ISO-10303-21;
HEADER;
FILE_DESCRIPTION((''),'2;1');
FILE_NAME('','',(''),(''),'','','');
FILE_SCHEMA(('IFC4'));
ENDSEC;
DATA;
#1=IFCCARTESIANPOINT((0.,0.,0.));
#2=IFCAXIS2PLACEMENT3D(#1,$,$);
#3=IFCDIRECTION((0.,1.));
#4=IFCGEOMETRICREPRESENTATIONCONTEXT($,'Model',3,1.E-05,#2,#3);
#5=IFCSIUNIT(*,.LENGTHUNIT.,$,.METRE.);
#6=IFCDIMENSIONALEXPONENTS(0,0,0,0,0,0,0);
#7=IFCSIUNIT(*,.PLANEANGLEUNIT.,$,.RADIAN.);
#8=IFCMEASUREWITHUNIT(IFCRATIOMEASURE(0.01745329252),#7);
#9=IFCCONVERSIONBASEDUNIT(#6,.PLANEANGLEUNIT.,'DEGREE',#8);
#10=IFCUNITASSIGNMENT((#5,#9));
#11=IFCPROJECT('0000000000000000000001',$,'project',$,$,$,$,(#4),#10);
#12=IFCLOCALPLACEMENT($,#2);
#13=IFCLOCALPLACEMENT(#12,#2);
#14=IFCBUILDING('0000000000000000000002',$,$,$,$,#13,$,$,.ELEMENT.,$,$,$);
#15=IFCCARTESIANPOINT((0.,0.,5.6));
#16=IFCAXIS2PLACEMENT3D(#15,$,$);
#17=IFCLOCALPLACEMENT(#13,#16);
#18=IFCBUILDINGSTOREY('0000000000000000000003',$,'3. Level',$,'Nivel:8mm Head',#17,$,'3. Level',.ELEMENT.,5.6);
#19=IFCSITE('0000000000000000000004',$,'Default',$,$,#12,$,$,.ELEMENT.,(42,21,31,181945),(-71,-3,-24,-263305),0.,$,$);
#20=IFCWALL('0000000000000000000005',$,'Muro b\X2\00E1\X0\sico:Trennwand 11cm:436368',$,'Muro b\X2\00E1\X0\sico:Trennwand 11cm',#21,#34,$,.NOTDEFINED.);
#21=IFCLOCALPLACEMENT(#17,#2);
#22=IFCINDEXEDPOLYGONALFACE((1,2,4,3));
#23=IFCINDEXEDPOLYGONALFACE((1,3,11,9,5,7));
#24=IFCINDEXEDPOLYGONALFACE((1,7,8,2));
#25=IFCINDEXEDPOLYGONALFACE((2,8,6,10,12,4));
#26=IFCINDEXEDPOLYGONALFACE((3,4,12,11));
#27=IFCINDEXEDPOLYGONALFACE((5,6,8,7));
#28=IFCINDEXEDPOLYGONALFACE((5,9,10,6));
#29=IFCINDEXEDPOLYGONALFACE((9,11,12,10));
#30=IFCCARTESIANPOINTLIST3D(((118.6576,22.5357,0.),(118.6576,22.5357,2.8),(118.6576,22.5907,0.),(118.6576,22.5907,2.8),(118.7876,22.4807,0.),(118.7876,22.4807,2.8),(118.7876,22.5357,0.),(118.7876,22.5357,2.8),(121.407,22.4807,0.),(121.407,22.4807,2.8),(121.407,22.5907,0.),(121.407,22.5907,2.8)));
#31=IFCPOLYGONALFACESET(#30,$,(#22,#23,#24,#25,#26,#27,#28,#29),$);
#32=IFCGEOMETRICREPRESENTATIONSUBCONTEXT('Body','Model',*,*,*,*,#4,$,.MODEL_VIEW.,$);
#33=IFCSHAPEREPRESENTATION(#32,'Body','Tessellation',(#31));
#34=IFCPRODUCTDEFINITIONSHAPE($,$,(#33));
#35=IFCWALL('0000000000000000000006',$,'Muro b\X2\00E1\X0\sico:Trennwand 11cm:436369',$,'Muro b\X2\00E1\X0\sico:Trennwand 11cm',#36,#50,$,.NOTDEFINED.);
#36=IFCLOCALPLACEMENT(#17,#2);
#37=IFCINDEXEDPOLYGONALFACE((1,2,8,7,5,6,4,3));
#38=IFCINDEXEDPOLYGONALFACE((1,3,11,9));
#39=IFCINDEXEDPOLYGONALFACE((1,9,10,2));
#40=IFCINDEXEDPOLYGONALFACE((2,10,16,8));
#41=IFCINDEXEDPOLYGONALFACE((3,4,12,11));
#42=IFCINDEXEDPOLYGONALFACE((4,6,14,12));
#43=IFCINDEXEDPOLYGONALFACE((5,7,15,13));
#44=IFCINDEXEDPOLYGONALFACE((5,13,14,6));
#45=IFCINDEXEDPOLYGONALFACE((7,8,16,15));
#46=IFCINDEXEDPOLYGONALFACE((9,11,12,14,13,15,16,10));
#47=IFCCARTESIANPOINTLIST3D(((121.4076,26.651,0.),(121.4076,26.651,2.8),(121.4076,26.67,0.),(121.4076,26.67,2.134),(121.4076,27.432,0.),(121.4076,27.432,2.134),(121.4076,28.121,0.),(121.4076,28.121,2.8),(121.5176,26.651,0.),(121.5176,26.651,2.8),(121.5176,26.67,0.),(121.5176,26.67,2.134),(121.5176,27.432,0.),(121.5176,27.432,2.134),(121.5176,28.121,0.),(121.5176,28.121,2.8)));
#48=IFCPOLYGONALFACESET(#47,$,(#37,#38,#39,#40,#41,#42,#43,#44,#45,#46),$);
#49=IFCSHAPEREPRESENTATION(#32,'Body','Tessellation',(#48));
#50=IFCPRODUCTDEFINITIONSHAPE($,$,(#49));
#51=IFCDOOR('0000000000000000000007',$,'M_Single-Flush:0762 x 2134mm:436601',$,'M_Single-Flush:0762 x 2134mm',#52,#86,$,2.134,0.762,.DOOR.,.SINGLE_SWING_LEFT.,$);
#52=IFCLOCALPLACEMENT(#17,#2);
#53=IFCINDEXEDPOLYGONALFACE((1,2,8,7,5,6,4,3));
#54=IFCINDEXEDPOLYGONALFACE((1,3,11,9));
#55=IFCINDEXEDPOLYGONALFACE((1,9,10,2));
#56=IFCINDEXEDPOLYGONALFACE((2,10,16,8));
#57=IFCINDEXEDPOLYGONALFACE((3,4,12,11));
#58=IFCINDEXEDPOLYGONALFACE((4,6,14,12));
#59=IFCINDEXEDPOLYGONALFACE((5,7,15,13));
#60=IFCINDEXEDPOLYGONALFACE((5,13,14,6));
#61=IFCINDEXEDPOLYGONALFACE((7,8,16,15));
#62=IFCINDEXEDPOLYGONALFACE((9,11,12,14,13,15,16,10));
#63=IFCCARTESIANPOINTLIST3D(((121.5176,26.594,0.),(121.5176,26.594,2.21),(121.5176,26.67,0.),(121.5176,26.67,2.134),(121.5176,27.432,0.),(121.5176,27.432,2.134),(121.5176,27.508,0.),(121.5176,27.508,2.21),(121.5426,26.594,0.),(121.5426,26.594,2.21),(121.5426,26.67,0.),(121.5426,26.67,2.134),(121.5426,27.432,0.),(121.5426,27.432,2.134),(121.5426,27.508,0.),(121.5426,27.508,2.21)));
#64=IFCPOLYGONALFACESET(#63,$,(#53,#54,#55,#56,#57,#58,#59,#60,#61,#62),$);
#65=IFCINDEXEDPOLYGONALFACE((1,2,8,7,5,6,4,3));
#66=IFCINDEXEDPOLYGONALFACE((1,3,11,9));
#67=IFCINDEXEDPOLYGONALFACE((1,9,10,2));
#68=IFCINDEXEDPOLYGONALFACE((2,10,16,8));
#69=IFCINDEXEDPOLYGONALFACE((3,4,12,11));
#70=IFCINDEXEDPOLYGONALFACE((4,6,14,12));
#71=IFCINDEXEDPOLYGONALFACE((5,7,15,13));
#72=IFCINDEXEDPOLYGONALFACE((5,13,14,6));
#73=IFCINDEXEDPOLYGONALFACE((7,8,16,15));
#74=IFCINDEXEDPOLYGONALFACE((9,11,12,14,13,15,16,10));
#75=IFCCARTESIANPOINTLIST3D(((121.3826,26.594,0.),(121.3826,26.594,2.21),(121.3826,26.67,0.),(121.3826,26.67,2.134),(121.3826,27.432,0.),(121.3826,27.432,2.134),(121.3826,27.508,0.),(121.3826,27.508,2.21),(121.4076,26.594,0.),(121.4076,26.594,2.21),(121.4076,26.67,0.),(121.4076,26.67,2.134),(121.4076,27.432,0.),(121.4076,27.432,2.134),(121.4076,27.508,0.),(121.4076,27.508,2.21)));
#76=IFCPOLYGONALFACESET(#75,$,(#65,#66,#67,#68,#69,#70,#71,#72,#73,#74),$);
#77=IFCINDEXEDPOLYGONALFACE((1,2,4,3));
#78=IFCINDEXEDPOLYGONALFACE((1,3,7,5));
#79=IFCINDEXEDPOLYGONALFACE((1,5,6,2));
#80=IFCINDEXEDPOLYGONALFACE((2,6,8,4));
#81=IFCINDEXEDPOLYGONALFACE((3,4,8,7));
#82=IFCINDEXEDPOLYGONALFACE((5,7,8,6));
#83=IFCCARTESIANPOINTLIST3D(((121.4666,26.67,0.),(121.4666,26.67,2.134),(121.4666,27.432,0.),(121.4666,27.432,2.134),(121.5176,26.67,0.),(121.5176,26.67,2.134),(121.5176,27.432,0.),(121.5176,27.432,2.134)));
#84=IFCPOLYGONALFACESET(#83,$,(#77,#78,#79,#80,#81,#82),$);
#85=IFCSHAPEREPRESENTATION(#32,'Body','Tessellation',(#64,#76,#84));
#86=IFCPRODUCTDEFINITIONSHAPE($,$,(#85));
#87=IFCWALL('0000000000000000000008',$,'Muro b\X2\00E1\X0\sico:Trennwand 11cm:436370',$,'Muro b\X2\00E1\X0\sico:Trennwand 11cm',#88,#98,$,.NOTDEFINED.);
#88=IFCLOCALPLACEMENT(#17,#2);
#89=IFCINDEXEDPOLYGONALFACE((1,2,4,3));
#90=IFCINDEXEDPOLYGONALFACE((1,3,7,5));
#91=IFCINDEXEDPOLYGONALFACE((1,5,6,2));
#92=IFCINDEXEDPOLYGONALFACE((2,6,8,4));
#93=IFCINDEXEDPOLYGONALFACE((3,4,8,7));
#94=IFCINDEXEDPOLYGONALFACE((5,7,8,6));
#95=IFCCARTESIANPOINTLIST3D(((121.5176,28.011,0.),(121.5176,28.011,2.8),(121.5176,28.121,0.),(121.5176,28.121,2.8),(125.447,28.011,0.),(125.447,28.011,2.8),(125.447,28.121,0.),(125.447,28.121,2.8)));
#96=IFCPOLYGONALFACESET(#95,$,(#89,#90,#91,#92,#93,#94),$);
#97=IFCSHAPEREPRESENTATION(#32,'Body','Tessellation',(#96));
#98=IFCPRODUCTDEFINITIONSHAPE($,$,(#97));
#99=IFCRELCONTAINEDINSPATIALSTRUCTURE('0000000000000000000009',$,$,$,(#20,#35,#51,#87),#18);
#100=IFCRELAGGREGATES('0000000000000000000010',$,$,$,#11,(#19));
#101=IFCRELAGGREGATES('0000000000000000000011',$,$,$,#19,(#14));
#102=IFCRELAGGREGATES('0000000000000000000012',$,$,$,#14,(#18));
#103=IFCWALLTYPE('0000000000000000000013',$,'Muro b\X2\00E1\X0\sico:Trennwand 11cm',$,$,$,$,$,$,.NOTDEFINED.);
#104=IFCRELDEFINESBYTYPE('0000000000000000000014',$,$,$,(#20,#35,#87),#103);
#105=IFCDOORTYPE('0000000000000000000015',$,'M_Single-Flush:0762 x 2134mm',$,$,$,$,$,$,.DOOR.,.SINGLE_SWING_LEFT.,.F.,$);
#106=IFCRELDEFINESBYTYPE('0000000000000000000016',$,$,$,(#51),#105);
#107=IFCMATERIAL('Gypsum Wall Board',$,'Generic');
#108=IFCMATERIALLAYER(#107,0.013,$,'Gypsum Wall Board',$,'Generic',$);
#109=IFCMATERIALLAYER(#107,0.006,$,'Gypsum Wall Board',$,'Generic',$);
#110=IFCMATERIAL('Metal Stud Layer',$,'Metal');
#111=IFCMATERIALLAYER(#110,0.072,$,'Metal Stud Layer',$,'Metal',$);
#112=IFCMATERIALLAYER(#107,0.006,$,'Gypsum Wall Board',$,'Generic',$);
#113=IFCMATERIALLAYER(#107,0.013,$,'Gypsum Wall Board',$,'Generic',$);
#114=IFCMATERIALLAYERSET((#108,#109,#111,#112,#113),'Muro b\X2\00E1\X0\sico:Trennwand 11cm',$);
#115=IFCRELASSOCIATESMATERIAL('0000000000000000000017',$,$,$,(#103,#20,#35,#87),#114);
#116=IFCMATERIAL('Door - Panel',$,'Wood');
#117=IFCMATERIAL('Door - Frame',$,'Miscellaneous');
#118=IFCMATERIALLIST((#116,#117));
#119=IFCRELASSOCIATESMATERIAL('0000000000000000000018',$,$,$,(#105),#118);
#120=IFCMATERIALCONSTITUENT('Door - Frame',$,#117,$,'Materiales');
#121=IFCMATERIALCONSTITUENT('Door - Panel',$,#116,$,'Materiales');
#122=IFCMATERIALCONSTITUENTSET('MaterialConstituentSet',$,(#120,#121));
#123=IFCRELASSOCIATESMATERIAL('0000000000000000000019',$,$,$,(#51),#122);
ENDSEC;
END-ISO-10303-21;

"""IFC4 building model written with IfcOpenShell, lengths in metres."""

from ifc_helpers import new_model, entity, si_unit, converted_unit, direction, frame, frame_2d, origin, origin_2d_with_axis, place, context, subcontext, project, spatial, polyline, rectangle, outline, extrude, source, transform, mapped, material, material_list, layer, layer_set, layer_usage, constituent, constituent_set, type_object, type_shapes, element, fill, save


model = new_model("IFC4")

# Units and contexts
model_context = context("Model", 3, precision=1e-05, world=origin(), true_north=direction((0.0, 1.0)))
body_context = subcontext(model_context, "Body", "Model", "MODEL_VIEW")
ifc_project = project(units=[si_unit("LENGTHUNIT", "METRE"), converted_unit("PLANEANGLEUNIT", "DEGREE", entity("IfcRatioMeasure", 0.01745329252), si_unit("PLANEANGLEUNIT", "RADIAN"), dimensions=[0, 0, 0, 0, 0, 0, 0])], contexts=[model_context])

# Site, building, storey
site_placement = place(None, origin())
site = spatial("IfcSite", under=ifc_project, at=site_placement, Name="Default", CompositionType="ELEMENT", RefLatitude=(42, 21, 31, 181945), RefLongitude=(-71, -3, -24, -263305), RefElevation=0.0)
building_placement = place(site_placement, origin())
building = spatial("IfcBuilding", under=site, at=building_placement, CompositionType="ELEMENT")
storey_placement = place(building_placement, frame((0.0, 0.0, 5.6)))
storey = spatial("IfcBuildingStorey", under=building, at=storey_placement, Name="3. Level", ObjectType="Nivel:8mm Head", LongName="3. Level", CompositionType="ELEMENT", Elevation=5.6)

# Shared definitions
ifc_material_1 = material(Name="Gypsum Wall Board", Category="Generic")
ifc_layer_1 = layer(ifc_material_1, 0.013, Name="Gypsum Wall Board", Category="Generic")
ifc_layer_2 = layer(ifc_material_1, 0.006, Name="Gypsum Wall Board", Category="Generic")
ifc_material_2 = material(Name="Metal Stud Layer", Category="Metal")
ifc_layer_3 = layer(ifc_material_2, 0.072, Name="Metal Stud Layer", Category="Metal")
ifc_layer_4 = layer(ifc_material_1, 0.006, Name="Gypsum Wall Board", Category="Generic")
ifc_layer_5 = layer(ifc_material_1, 0.013, Name="Gypsum Wall Board", Category="Generic")
ifc_layer_set_1 = layer_set([ifc_layer_1, ifc_layer_2, ifc_layer_3, ifc_layer_4, ifc_layer_5], Name="Muro básico:Trennwand 11cm")
wall_type_1 = type_object("IfcWallType", Name="Muro básico:Trennwand 11cm", PredefinedType="NOTDEFINED", material=ifc_layer_set_1)
ifc_material_3 = material(Name="Door - Frame", Category="Miscellaneous")

# Wall
ifc_layer_usage_1 = layer_usage(ifc_layer_set_1, "AXIS2", "NEGATIVE", 0.055)
wall_1_placement = place(storey_placement, frame((121.407, 22.5357, 0.0), z_axis=(0.0, 0.0, 1.0), x_axis=(-1.0, 0.0, 0.0)))
element("IfcWall", 1, at=wall_1_placement, inside=storey, type_object=wall_type_1, material=ifc_layer_usage_1, Name="Muro básico:Trennwand 11cm:436368", ObjectType="Muro básico:Trennwand 11cm", PredefinedType="NOTDEFINED", context=body_context, shape_type="SweptSolid", body=[
    extrude(outline(polyline([(2.7494, -0.055), (2.7494, 0.0), (2.6194, 0.0), (2.6194, 0.055), (0.0, 0.055), (0.0, -0.055), (2.7494, -0.055)])), origin(), (0.0, 0.0, 1.0), 2.8),
])

# Wall, opening, door
ifc_layer_usage_2 = layer_usage(ifc_layer_set_1, "AXIS2", "NEGATIVE", 0.055)
wall_2_placement = place(storey_placement, frame((121.4626, 26.651, 0.0), z_axis=(0.0, 0.0, 1.0), x_axis=(0.0, 1.0, 0.0)))
wall_2 = element("IfcWall", 2, at=wall_2_placement, inside=storey, type_object=wall_type_1, material=ifc_layer_usage_2, Name="Muro básico:Trennwand 11cm:436369", ObjectType="Muro básico:Trennwand 11cm", PredefinedType="NOTDEFINED", context=body_context, shape_type="SweptSolid", body=[
    extrude(rectangle(XDim=1.47, YDim=0.11, at=frame_2d((0.735, 0.0), x_axis=(-1.0, 0.0))), origin(), (0.0, 0.0, 1.0), 2.8),
])
opening_1_placement = place(wall_2_placement, frame((0.781, 0.055, 0.0)))
opening_1 = element("IfcOpeningElement", 3, at=opening_1_placement, cuts=wall_2, ObjectType="Opening", PredefinedType="OPENING", context=body_context, shape_type="SweptSolid", body=[
    extrude(rectangle(XDim=0.762, YDim=2.134, at=frame_2d((1.067, 0.381), x_axis=(0.0, -1.0))), frame((0.0, 0.0, 0.0), z_axis=(0.0, -1.0, 0.0), x_axis=(0.0, 0.0, 1.0)), (0.0, 0.0, 1.0), 0.11),
])
ifc_constituent_1 = constituent(ifc_material_3, Name="Door - Frame", Category="Materiales")
ifc_material_4 = material(Name="Door - Panel", Category="Wood")
ifc_constituent_2 = constituent(ifc_material_4, Name="Door - Panel", Category="Materiales")
ifc_constituent_set_1 = constituent_set(constituents=[ifc_constituent_1, ifc_constituent_2], Name="MaterialConstituentSet")
ifc_material_list_1 = material_list([ifc_material_4, ifc_material_3])
door_type_1 = type_object("IfcDoorType", Name="M_Single-Flush:0762 x 2134mm", OperationType="SINGLE_SWING_LEFT", ParameterTakesPrecedence=False, PredefinedType="DOOR", material=ifc_material_list_1)
shared_shape_1 = source(origin(), body_context, "Body", "SweptSolid", [
    extrude(outline(polyline([(-0.457, -1.124), (0.457, -1.124), (0.457, 1.086), (0.381, 1.086), (0.381, -1.048), (-0.381, -1.048), (-0.381, 1.086), (-0.457, 1.086), (-0.457, -1.124)])), frame((0.381, 0.135, 1.086), z_axis=(0.0, -1.0, 0.0), x_axis=(-1.0, 0.0, 0.0)), (0.0, 0.0, 1.0), 0.025),
    extrude(outline(polyline([(-1.124, -0.457), (1.086, -0.457), (1.086, -0.381), (-1.048, -0.381), (-1.048, 0.381), (1.086, 0.381), (1.086, 0.457), (-1.124, 0.457), (-1.124, -0.457)])), frame((0.381, 0.0, 1.086), z_axis=(0.0, -1.0, 0.0), x_axis=(0.0, 0.0, -1.0)), (0.0, 0.0, 1.0), 0.025),
    extrude(rectangle(XDim=0.762, YDim=0.051, at=origin_2d_with_axis()), frame((0.381, 0.0845, 0.0)), (0.0, 0.0, 1.0), 2.134),
])
type_shapes(door_type_1, [shared_shape_1])
door_1_placement = place(opening_1_placement, frame((0.0, 0.0, 0.0), z_axis=(0.0, 0.0, 1.0), x_axis=(-1.0, 0.0, 0.0)))
door_1 = element("IfcDoor", 4, at=door_1_placement, inside=storey, type_object=door_type_1, material=ifc_constituent_set_1, Name="M_Single-Flush:0762 x 2134mm:436601", ObjectType="M_Single-Flush:0762 x 2134mm", OperationType="SINGLE_SWING_LEFT", OverallHeight=2.134, OverallWidth=0.762, PredefinedType="DOOR", context=body_context, shape_type="MappedRepresentation", body=[
    mapped(shared_shape_1, transform((0.0, 0.0, 0.0), scale=1.0)),
])
fill(opening_1, door_1)

# Wall
ifc_layer_usage_3 = layer_usage(ifc_layer_set_1, "AXIS2", "NEGATIVE", 0.055)
wall_3_placement = place(storey_placement, frame((121.5176, 28.066, 0.0)))
element("IfcWall", 5, at=wall_3_placement, inside=storey, type_object=wall_type_1, material=ifc_layer_usage_3, Name="Muro básico:Trennwand 11cm:436370", ObjectType="Muro básico:Trennwand 11cm", PredefinedType="NOTDEFINED", context=body_context, shape_type="SweptSolid", body=[
    extrude(rectangle(XDim=3.9294, YDim=0.11, at=frame_2d((1.9647, 0.0), x_axis=(-1.0, 0.0))), origin(), (0.0, 0.0, 1.0), 2.8),
])

save(model, "model.ifc")
